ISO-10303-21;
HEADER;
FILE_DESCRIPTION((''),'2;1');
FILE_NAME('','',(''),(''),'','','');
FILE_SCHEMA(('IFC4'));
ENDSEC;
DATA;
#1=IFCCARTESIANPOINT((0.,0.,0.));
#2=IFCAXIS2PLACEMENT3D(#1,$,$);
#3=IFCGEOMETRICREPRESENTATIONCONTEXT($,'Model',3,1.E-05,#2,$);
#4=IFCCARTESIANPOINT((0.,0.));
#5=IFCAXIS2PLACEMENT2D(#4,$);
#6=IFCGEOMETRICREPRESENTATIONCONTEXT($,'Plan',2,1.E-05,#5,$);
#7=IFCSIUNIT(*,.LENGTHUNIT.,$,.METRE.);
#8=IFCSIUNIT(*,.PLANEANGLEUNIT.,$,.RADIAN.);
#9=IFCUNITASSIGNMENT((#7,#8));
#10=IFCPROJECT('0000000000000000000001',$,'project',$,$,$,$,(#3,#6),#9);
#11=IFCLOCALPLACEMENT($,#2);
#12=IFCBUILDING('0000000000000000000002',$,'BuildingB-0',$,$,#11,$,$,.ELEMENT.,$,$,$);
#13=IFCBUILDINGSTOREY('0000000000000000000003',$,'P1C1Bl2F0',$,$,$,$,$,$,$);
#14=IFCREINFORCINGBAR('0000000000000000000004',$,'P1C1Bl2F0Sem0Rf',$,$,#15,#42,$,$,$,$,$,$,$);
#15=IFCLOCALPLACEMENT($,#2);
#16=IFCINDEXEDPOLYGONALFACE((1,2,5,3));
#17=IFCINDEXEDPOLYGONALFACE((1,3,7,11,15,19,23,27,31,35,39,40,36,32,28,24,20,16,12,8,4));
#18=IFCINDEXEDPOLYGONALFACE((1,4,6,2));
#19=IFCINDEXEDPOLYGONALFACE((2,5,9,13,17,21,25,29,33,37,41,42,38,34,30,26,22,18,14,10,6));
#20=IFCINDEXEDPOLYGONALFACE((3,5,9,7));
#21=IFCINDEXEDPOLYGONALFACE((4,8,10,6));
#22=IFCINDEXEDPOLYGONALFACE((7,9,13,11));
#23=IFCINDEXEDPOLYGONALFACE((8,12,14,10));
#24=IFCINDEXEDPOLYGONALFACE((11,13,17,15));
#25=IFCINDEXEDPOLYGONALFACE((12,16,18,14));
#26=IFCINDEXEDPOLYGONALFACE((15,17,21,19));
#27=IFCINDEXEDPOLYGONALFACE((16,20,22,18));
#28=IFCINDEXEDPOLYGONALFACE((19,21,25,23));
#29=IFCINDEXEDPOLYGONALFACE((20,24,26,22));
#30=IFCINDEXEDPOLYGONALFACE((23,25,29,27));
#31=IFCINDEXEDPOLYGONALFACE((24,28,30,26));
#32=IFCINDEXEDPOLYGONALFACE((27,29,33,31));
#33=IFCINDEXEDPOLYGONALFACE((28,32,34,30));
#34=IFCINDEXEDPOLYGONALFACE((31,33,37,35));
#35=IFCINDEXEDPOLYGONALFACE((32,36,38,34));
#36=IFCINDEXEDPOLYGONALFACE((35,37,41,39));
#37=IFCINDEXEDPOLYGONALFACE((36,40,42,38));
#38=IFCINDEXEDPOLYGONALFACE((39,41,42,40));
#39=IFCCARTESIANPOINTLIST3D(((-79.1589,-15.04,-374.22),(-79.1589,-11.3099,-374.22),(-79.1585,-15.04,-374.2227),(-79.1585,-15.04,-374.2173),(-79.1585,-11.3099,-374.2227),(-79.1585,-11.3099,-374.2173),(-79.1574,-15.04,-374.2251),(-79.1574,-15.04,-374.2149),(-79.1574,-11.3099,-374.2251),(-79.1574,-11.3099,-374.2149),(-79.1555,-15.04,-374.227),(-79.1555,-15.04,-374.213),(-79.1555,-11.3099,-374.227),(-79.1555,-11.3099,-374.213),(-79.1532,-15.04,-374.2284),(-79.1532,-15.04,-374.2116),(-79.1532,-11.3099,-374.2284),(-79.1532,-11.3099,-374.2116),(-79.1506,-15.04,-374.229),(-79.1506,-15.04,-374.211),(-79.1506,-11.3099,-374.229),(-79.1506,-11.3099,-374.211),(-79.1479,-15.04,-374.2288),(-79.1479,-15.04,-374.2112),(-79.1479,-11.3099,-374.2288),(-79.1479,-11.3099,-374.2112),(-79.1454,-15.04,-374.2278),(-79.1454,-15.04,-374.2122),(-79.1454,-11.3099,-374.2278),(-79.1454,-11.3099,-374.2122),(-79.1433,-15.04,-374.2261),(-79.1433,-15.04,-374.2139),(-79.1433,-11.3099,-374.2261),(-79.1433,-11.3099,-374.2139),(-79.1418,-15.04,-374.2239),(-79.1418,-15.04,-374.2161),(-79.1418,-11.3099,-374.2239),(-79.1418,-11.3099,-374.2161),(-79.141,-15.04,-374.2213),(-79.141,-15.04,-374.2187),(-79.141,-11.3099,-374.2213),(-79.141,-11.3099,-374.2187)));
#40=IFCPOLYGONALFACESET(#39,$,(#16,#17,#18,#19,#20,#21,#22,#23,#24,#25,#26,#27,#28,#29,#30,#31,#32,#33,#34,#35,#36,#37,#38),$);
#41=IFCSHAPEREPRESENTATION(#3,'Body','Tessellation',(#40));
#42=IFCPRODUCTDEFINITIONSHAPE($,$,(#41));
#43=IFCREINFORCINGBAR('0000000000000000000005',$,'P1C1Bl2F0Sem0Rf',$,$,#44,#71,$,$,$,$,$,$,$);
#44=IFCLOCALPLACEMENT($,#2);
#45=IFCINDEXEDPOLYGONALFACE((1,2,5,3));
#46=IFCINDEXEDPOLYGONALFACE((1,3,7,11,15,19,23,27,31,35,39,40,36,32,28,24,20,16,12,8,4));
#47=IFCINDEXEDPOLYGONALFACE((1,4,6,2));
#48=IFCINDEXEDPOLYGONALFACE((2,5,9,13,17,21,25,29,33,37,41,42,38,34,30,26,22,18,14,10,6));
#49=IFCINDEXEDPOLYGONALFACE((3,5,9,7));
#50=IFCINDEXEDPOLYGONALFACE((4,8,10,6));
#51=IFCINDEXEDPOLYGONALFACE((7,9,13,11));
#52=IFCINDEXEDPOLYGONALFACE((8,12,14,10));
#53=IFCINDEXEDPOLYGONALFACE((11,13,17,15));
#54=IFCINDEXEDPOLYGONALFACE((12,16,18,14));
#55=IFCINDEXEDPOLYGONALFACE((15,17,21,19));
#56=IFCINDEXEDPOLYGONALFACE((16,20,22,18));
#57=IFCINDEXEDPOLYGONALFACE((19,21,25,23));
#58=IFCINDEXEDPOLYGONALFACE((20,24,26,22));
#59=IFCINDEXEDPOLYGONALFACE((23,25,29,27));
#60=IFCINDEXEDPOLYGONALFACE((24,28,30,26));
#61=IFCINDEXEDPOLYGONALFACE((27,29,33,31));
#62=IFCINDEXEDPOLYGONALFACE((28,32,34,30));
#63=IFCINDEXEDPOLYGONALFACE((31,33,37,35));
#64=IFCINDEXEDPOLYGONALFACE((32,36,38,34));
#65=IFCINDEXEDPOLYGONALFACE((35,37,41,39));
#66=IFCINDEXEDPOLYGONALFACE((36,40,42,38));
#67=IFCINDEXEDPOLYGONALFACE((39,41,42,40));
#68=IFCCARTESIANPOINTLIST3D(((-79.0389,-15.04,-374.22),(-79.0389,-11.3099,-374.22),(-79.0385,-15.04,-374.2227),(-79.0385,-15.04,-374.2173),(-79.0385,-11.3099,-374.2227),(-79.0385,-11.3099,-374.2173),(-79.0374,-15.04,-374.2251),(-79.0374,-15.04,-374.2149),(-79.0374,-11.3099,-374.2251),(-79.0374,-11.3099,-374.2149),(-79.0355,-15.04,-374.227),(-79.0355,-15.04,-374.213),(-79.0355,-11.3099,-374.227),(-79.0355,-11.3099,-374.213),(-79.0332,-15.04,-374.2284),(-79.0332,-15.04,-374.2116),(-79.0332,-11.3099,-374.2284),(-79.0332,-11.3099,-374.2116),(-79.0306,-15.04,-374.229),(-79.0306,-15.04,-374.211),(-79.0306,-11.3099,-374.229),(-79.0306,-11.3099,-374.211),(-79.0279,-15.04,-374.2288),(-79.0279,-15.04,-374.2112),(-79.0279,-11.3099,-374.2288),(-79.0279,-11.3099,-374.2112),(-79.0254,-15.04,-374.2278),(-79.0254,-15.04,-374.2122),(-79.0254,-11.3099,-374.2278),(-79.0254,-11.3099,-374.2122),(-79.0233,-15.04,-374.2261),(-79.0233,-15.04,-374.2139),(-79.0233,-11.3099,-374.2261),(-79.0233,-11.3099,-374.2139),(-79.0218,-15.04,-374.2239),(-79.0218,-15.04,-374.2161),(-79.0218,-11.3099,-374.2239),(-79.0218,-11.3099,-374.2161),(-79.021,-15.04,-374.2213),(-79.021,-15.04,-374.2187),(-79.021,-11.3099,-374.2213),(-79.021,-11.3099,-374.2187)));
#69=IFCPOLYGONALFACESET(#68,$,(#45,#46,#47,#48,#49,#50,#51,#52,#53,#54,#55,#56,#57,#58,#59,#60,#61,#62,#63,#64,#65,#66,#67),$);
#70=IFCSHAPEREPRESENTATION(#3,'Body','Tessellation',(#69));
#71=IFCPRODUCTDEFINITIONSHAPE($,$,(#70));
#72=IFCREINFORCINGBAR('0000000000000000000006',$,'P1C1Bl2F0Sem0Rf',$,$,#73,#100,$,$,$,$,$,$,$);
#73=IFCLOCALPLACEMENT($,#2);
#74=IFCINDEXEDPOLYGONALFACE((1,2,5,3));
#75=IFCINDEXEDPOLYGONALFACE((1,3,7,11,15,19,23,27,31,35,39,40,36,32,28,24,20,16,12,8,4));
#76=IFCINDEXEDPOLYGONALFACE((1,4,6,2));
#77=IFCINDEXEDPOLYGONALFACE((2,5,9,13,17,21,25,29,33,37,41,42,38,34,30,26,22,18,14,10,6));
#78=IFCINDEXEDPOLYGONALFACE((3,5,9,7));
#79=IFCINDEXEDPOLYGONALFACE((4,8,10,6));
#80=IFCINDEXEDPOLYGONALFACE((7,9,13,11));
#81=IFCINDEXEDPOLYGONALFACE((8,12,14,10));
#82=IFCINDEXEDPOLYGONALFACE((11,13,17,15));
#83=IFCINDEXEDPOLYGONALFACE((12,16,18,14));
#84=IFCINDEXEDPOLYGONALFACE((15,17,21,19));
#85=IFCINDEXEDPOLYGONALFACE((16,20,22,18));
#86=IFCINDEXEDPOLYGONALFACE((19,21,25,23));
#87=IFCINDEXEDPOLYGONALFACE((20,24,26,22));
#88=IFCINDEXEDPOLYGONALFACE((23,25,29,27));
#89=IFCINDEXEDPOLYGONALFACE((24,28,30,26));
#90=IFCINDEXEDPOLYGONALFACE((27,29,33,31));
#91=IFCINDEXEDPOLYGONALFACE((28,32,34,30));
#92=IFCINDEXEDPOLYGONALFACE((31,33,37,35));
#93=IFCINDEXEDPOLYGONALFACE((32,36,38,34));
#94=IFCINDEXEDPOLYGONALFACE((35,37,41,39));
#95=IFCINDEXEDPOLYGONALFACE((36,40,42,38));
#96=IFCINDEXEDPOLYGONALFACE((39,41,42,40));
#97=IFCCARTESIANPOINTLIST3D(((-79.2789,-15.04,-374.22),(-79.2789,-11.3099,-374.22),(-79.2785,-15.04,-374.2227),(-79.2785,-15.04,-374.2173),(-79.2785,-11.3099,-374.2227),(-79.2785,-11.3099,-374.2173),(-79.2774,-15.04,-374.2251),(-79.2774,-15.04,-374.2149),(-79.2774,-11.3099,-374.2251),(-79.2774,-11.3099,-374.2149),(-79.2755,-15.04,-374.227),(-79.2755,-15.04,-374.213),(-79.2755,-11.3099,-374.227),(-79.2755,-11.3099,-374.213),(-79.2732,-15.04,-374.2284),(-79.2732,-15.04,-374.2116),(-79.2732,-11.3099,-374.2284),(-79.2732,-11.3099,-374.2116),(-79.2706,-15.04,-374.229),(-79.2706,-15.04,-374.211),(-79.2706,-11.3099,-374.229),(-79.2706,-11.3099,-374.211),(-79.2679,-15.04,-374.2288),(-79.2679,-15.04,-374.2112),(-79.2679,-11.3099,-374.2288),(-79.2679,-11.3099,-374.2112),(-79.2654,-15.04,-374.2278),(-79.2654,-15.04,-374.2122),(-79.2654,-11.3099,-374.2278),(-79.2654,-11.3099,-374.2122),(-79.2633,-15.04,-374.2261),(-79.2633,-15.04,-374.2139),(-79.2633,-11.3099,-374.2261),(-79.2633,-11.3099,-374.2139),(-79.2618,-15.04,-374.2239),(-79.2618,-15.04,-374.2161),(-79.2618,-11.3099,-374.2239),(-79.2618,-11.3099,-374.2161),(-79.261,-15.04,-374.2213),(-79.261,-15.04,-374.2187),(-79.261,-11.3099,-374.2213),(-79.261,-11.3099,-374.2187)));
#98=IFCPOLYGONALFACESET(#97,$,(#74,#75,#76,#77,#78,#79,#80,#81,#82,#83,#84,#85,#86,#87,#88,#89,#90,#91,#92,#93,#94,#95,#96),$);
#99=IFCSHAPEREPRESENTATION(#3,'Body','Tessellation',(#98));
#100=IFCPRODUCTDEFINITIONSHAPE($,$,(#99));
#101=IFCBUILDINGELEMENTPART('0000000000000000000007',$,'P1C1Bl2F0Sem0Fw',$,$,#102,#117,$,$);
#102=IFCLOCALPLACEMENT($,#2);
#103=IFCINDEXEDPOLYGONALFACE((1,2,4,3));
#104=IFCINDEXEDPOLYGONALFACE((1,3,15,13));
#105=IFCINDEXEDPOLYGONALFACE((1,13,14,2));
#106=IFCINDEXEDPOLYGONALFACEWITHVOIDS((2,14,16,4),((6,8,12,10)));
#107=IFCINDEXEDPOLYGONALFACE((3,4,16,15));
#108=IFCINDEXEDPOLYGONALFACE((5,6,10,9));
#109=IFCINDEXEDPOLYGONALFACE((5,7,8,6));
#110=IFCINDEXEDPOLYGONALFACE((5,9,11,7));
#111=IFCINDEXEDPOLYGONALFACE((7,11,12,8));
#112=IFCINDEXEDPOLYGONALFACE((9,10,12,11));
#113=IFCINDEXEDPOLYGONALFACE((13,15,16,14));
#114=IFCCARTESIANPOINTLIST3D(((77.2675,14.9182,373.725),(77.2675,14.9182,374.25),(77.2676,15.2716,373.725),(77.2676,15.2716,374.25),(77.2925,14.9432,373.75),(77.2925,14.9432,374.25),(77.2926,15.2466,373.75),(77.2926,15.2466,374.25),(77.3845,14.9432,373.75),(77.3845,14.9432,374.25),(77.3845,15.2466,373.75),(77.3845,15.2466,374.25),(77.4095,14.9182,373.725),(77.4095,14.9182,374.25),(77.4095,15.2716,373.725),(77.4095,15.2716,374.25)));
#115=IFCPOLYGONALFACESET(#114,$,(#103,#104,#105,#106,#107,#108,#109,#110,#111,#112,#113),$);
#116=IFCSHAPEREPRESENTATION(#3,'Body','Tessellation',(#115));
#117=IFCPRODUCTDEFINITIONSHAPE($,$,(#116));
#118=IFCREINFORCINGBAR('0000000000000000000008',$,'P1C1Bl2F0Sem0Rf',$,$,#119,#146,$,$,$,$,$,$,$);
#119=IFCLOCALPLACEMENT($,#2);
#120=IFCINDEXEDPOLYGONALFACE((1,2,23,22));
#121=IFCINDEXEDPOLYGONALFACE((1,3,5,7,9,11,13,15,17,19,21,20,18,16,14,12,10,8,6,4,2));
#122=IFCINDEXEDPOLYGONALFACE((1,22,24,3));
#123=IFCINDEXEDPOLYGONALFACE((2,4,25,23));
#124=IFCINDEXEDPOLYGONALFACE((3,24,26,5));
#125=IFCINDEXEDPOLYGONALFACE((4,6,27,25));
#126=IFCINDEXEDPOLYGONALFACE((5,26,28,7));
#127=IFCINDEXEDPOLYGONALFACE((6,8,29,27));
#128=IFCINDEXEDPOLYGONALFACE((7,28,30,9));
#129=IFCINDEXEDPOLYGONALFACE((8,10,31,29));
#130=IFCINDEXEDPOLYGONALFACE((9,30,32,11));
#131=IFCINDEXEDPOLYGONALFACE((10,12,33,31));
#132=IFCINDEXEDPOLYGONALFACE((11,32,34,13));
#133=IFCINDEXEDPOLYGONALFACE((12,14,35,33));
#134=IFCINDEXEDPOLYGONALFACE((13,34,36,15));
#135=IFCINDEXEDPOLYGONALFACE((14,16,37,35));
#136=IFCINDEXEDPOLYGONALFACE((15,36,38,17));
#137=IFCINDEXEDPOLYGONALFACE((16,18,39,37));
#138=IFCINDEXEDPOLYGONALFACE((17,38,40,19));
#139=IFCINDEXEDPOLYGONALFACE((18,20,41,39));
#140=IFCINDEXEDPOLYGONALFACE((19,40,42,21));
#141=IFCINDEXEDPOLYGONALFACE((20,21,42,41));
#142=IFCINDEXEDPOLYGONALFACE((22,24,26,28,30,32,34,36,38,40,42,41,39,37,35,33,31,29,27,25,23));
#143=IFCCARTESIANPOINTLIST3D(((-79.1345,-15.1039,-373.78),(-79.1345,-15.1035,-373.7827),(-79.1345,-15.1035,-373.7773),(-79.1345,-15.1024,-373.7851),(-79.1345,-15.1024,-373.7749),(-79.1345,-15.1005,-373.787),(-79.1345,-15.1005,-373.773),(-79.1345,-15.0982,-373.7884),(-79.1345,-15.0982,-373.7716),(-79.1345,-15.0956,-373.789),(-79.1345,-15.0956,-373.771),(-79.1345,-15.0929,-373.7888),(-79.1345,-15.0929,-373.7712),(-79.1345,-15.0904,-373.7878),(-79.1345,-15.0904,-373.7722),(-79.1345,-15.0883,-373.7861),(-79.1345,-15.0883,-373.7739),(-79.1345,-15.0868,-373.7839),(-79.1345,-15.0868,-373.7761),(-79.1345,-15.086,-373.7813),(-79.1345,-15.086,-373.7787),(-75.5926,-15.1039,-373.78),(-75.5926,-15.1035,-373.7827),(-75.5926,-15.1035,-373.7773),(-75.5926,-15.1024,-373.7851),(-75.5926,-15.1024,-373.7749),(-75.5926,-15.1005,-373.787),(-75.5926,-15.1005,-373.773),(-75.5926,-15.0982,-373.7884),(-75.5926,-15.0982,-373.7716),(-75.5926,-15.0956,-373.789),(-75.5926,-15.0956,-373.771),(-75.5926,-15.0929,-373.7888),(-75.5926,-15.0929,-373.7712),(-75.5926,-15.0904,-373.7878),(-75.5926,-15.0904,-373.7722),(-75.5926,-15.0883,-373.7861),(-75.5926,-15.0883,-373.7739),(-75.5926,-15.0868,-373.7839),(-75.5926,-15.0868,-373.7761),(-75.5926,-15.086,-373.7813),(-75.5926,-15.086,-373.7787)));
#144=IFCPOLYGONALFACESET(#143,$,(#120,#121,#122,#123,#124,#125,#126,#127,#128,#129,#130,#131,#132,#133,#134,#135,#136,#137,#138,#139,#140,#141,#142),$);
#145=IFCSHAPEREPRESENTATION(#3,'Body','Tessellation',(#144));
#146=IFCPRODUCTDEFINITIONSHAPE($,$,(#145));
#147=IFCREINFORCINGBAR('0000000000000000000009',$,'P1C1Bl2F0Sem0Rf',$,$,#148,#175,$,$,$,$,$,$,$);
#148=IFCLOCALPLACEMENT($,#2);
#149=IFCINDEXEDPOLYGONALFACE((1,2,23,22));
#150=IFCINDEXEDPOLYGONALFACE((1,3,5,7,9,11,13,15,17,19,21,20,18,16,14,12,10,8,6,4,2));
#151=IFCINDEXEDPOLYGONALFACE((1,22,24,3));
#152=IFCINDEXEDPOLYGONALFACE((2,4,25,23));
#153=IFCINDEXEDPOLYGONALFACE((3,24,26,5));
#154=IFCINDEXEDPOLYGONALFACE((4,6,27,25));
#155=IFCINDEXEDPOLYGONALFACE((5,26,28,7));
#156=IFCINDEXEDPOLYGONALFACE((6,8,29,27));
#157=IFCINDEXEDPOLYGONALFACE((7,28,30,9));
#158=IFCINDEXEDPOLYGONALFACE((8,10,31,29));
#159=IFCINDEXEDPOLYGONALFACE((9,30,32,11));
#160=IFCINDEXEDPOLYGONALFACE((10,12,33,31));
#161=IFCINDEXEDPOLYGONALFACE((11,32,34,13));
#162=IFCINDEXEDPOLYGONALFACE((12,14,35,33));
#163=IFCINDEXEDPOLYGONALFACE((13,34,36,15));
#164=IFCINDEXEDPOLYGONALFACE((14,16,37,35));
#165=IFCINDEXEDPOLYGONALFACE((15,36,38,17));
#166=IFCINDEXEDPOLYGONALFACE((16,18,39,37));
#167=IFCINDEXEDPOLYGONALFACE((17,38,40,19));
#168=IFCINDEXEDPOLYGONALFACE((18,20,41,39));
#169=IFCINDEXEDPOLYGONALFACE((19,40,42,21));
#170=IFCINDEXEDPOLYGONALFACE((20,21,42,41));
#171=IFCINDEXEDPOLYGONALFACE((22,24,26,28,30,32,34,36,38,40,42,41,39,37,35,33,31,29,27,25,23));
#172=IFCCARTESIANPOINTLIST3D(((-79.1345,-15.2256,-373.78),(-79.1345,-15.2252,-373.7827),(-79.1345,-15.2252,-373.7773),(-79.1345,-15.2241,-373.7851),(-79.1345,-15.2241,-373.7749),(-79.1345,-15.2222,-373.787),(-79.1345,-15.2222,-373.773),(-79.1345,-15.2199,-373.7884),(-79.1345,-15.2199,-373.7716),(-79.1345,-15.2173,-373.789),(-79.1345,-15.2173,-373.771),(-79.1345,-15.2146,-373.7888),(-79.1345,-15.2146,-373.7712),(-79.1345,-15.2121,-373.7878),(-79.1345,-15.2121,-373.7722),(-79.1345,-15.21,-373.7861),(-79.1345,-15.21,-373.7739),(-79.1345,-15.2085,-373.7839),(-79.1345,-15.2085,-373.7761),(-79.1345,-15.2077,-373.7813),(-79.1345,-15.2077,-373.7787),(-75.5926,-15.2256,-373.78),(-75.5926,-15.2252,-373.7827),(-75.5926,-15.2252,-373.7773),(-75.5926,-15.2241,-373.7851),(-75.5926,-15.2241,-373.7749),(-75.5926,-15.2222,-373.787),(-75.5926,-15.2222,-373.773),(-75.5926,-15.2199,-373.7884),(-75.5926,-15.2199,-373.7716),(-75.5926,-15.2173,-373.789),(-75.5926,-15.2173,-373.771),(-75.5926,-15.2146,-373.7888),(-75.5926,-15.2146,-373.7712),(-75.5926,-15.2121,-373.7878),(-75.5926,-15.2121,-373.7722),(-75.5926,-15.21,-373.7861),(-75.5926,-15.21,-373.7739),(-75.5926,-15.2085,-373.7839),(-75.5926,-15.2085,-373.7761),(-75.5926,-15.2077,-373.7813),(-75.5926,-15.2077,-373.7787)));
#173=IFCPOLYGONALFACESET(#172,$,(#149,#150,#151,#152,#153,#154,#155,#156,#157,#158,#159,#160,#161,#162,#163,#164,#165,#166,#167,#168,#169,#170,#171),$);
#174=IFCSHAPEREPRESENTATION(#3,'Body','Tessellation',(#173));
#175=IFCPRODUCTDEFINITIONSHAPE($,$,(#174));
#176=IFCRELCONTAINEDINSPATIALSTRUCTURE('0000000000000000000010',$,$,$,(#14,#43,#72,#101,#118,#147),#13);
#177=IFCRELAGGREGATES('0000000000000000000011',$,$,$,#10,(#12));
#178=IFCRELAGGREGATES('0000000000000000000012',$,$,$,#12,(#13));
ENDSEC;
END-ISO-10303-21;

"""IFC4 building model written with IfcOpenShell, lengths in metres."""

from ifc_helpers import new_model, entity, si_unit, origin, origin_2d, place, context, project, spatial, polyline, outline, extrude, element, save


model = new_model("IFC4")

# Units and contexts
model_context = context("Model", 3, precision=1e-05, world=origin())
plan_context = context("Plan", 2, precision=1e-05, world=origin_2d())
ifc_project = project(units=[si_unit("LENGTHUNIT", "METRE"), si_unit("PLANEANGLEUNIT", "RADIAN")], contexts=[model_context, plan_context])

# Building, storey
building_placement = place(None, origin())
building = spatial("IfcBuilding", under=ifc_project, at=building_placement, Name="BuildingB-0", CompositionType="ELEMENT")
storey = spatial("IfcBuildingStorey", under=building, Name="P1C1Bl2F0")

# Reinforcing bars
element("IfcReinforcingBar", 1, inside=storey, Name="P1C1Bl2F0Sem0Rf", context=model_context, shape_type="SweptSolid", body=[
    entity("IfcSurfaceCurveSweptAreaSolid", entity("IfcCircleProfileDef", "AREA", None, None, 0.009), None, entity("IfcPolyline", [entity("IfcCartesianPoint", [79.1499, 15.04, 374.22]), entity("IfcCartesianPoint", [79.1499, 11.3099, 374.22])]), None, None, entity("IfcPlane", entity("IfcAxis2Placement3D", entity("IfcCartesianPoint", [79.1499, 15.04, 374.22]), entity("IfcDirection", [0.0, 0.0, 1.0]), entity("IfcDirection", [1.0, 0.0, 0.0])))),
])
element("IfcReinforcingBar", 2, inside=storey, Name="P1C1Bl2F0Sem0Rf", context=model_context, shape_type="SweptSolid", body=[
    entity("IfcSurfaceCurveSweptAreaSolid", entity("IfcCircleProfileDef", "AREA", None, None, 0.009), None, entity("IfcPolyline", [entity("IfcCartesianPoint", [79.0299, 15.04, 374.22]), entity("IfcCartesianPoint", [79.0299, 11.3099, 374.22])]), None, None, entity("IfcPlane", entity("IfcAxis2Placement3D", entity("IfcCartesianPoint", [79.0299, 15.04, 374.22]), entity("IfcDirection", [0.0, 0.0, 1.0]), entity("IfcDirection", [1.0, 0.0, 0.0])))),
])
element("IfcReinforcingBar", 3, inside=storey, Name="P1C1Bl2F0Sem0Rf", context=model_context, shape_type="SweptSolid", body=[
    entity("IfcSurfaceCurveSweptAreaSolid", entity("IfcCircleProfileDef", "AREA", None, None, 0.009), None, entity("IfcPolyline", [entity("IfcCartesianPoint", [79.2699, 15.04, 374.22]), entity("IfcCartesianPoint", [79.2699, 11.3099, 374.22])]), None, None, entity("IfcPlane", entity("IfcAxis2Placement3D", entity("IfcCartesianPoint", [79.2699, 15.04, 374.22]), entity("IfcDirection", [0.0, 0.0, 1.0]), entity("IfcDirection", [1.0, 0.0, 0.0])))),
])

# Building element part, opening
building_element_part_1 = element("IfcBuildingElementPart", 4, inside=storey, Name="P1C1Bl2F0Sem0Fw", context=model_context, shape_type="SweptSolid", body=[
    extrude(outline(polyline([(77.4095, 14.9182, 373.725), (77.2675, 14.9182, 373.725), (77.2676, 15.2716, 373.725), (77.4095, 15.2716, 373.725), (77.4095, 14.9182, 373.725)])), None, (0.0, 0.0, 1.0), 0.525),
])
element("IfcOpeningElement", 5, inside=storey, cuts=building_element_part_1, context=model_context, shape_type="SweptSolid", body=[
    extrude(outline(polyline([(77.3845, 14.9432, 373.75), (77.2925, 14.9432, 373.75), (77.2926, 15.2466, 373.75), (77.3845, 15.2466, 373.75), (77.3845, 14.9432, 373.75)])), None, (0.0, 0.0, 1.0), 0.5),
])

# Reinforcing bars
element("IfcReinforcingBar", 6, inside=storey, Name="P1C1Bl2F0Sem0Rf", context=model_context, shape_type="SweptSolid", body=[
    entity("IfcSurfaceCurveSweptAreaSolid", entity("IfcCircleProfileDef", "AREA", None, None, 0.009), None, entity("IfcPolyline", [entity("IfcCartesianPoint", [79.1345, 15.0949, 373.78]), entity("IfcCartesianPoint", [75.5926, 15.0949, 373.78])]), None, None, entity("IfcPlane", entity("IfcAxis2Placement3D", entity("IfcCartesianPoint", [79.1345, 15.0949, 373.78]), entity("IfcDirection", [0.0, 0.0, 1.0]), entity("IfcDirection", [1.0, 0.0, 0.0])))),
])
element("IfcReinforcingBar", 7, inside=storey, Name="P1C1Bl2F0Sem0Rf", context=model_context, shape_type="SweptSolid", body=[
    entity("IfcSurfaceCurveSweptAreaSolid", entity("IfcCircleProfileDef", "AREA", None, None, 0.009), None, entity("IfcPolyline", [entity("IfcCartesianPoint", [79.1345, 15.2166, 373.78]), entity("IfcCartesianPoint", [75.5926, 15.2166, 373.78])]), None, None, entity("IfcPlane", entity("IfcAxis2Placement3D", entity("IfcCartesianPoint", [79.1345, 15.2166, 373.78]), entity("IfcDirection", [0.0, 0.0, 1.0]), entity("IfcDirection", [1.0, 0.0, 0.0])))),
])

save(model, "model.ifc")
